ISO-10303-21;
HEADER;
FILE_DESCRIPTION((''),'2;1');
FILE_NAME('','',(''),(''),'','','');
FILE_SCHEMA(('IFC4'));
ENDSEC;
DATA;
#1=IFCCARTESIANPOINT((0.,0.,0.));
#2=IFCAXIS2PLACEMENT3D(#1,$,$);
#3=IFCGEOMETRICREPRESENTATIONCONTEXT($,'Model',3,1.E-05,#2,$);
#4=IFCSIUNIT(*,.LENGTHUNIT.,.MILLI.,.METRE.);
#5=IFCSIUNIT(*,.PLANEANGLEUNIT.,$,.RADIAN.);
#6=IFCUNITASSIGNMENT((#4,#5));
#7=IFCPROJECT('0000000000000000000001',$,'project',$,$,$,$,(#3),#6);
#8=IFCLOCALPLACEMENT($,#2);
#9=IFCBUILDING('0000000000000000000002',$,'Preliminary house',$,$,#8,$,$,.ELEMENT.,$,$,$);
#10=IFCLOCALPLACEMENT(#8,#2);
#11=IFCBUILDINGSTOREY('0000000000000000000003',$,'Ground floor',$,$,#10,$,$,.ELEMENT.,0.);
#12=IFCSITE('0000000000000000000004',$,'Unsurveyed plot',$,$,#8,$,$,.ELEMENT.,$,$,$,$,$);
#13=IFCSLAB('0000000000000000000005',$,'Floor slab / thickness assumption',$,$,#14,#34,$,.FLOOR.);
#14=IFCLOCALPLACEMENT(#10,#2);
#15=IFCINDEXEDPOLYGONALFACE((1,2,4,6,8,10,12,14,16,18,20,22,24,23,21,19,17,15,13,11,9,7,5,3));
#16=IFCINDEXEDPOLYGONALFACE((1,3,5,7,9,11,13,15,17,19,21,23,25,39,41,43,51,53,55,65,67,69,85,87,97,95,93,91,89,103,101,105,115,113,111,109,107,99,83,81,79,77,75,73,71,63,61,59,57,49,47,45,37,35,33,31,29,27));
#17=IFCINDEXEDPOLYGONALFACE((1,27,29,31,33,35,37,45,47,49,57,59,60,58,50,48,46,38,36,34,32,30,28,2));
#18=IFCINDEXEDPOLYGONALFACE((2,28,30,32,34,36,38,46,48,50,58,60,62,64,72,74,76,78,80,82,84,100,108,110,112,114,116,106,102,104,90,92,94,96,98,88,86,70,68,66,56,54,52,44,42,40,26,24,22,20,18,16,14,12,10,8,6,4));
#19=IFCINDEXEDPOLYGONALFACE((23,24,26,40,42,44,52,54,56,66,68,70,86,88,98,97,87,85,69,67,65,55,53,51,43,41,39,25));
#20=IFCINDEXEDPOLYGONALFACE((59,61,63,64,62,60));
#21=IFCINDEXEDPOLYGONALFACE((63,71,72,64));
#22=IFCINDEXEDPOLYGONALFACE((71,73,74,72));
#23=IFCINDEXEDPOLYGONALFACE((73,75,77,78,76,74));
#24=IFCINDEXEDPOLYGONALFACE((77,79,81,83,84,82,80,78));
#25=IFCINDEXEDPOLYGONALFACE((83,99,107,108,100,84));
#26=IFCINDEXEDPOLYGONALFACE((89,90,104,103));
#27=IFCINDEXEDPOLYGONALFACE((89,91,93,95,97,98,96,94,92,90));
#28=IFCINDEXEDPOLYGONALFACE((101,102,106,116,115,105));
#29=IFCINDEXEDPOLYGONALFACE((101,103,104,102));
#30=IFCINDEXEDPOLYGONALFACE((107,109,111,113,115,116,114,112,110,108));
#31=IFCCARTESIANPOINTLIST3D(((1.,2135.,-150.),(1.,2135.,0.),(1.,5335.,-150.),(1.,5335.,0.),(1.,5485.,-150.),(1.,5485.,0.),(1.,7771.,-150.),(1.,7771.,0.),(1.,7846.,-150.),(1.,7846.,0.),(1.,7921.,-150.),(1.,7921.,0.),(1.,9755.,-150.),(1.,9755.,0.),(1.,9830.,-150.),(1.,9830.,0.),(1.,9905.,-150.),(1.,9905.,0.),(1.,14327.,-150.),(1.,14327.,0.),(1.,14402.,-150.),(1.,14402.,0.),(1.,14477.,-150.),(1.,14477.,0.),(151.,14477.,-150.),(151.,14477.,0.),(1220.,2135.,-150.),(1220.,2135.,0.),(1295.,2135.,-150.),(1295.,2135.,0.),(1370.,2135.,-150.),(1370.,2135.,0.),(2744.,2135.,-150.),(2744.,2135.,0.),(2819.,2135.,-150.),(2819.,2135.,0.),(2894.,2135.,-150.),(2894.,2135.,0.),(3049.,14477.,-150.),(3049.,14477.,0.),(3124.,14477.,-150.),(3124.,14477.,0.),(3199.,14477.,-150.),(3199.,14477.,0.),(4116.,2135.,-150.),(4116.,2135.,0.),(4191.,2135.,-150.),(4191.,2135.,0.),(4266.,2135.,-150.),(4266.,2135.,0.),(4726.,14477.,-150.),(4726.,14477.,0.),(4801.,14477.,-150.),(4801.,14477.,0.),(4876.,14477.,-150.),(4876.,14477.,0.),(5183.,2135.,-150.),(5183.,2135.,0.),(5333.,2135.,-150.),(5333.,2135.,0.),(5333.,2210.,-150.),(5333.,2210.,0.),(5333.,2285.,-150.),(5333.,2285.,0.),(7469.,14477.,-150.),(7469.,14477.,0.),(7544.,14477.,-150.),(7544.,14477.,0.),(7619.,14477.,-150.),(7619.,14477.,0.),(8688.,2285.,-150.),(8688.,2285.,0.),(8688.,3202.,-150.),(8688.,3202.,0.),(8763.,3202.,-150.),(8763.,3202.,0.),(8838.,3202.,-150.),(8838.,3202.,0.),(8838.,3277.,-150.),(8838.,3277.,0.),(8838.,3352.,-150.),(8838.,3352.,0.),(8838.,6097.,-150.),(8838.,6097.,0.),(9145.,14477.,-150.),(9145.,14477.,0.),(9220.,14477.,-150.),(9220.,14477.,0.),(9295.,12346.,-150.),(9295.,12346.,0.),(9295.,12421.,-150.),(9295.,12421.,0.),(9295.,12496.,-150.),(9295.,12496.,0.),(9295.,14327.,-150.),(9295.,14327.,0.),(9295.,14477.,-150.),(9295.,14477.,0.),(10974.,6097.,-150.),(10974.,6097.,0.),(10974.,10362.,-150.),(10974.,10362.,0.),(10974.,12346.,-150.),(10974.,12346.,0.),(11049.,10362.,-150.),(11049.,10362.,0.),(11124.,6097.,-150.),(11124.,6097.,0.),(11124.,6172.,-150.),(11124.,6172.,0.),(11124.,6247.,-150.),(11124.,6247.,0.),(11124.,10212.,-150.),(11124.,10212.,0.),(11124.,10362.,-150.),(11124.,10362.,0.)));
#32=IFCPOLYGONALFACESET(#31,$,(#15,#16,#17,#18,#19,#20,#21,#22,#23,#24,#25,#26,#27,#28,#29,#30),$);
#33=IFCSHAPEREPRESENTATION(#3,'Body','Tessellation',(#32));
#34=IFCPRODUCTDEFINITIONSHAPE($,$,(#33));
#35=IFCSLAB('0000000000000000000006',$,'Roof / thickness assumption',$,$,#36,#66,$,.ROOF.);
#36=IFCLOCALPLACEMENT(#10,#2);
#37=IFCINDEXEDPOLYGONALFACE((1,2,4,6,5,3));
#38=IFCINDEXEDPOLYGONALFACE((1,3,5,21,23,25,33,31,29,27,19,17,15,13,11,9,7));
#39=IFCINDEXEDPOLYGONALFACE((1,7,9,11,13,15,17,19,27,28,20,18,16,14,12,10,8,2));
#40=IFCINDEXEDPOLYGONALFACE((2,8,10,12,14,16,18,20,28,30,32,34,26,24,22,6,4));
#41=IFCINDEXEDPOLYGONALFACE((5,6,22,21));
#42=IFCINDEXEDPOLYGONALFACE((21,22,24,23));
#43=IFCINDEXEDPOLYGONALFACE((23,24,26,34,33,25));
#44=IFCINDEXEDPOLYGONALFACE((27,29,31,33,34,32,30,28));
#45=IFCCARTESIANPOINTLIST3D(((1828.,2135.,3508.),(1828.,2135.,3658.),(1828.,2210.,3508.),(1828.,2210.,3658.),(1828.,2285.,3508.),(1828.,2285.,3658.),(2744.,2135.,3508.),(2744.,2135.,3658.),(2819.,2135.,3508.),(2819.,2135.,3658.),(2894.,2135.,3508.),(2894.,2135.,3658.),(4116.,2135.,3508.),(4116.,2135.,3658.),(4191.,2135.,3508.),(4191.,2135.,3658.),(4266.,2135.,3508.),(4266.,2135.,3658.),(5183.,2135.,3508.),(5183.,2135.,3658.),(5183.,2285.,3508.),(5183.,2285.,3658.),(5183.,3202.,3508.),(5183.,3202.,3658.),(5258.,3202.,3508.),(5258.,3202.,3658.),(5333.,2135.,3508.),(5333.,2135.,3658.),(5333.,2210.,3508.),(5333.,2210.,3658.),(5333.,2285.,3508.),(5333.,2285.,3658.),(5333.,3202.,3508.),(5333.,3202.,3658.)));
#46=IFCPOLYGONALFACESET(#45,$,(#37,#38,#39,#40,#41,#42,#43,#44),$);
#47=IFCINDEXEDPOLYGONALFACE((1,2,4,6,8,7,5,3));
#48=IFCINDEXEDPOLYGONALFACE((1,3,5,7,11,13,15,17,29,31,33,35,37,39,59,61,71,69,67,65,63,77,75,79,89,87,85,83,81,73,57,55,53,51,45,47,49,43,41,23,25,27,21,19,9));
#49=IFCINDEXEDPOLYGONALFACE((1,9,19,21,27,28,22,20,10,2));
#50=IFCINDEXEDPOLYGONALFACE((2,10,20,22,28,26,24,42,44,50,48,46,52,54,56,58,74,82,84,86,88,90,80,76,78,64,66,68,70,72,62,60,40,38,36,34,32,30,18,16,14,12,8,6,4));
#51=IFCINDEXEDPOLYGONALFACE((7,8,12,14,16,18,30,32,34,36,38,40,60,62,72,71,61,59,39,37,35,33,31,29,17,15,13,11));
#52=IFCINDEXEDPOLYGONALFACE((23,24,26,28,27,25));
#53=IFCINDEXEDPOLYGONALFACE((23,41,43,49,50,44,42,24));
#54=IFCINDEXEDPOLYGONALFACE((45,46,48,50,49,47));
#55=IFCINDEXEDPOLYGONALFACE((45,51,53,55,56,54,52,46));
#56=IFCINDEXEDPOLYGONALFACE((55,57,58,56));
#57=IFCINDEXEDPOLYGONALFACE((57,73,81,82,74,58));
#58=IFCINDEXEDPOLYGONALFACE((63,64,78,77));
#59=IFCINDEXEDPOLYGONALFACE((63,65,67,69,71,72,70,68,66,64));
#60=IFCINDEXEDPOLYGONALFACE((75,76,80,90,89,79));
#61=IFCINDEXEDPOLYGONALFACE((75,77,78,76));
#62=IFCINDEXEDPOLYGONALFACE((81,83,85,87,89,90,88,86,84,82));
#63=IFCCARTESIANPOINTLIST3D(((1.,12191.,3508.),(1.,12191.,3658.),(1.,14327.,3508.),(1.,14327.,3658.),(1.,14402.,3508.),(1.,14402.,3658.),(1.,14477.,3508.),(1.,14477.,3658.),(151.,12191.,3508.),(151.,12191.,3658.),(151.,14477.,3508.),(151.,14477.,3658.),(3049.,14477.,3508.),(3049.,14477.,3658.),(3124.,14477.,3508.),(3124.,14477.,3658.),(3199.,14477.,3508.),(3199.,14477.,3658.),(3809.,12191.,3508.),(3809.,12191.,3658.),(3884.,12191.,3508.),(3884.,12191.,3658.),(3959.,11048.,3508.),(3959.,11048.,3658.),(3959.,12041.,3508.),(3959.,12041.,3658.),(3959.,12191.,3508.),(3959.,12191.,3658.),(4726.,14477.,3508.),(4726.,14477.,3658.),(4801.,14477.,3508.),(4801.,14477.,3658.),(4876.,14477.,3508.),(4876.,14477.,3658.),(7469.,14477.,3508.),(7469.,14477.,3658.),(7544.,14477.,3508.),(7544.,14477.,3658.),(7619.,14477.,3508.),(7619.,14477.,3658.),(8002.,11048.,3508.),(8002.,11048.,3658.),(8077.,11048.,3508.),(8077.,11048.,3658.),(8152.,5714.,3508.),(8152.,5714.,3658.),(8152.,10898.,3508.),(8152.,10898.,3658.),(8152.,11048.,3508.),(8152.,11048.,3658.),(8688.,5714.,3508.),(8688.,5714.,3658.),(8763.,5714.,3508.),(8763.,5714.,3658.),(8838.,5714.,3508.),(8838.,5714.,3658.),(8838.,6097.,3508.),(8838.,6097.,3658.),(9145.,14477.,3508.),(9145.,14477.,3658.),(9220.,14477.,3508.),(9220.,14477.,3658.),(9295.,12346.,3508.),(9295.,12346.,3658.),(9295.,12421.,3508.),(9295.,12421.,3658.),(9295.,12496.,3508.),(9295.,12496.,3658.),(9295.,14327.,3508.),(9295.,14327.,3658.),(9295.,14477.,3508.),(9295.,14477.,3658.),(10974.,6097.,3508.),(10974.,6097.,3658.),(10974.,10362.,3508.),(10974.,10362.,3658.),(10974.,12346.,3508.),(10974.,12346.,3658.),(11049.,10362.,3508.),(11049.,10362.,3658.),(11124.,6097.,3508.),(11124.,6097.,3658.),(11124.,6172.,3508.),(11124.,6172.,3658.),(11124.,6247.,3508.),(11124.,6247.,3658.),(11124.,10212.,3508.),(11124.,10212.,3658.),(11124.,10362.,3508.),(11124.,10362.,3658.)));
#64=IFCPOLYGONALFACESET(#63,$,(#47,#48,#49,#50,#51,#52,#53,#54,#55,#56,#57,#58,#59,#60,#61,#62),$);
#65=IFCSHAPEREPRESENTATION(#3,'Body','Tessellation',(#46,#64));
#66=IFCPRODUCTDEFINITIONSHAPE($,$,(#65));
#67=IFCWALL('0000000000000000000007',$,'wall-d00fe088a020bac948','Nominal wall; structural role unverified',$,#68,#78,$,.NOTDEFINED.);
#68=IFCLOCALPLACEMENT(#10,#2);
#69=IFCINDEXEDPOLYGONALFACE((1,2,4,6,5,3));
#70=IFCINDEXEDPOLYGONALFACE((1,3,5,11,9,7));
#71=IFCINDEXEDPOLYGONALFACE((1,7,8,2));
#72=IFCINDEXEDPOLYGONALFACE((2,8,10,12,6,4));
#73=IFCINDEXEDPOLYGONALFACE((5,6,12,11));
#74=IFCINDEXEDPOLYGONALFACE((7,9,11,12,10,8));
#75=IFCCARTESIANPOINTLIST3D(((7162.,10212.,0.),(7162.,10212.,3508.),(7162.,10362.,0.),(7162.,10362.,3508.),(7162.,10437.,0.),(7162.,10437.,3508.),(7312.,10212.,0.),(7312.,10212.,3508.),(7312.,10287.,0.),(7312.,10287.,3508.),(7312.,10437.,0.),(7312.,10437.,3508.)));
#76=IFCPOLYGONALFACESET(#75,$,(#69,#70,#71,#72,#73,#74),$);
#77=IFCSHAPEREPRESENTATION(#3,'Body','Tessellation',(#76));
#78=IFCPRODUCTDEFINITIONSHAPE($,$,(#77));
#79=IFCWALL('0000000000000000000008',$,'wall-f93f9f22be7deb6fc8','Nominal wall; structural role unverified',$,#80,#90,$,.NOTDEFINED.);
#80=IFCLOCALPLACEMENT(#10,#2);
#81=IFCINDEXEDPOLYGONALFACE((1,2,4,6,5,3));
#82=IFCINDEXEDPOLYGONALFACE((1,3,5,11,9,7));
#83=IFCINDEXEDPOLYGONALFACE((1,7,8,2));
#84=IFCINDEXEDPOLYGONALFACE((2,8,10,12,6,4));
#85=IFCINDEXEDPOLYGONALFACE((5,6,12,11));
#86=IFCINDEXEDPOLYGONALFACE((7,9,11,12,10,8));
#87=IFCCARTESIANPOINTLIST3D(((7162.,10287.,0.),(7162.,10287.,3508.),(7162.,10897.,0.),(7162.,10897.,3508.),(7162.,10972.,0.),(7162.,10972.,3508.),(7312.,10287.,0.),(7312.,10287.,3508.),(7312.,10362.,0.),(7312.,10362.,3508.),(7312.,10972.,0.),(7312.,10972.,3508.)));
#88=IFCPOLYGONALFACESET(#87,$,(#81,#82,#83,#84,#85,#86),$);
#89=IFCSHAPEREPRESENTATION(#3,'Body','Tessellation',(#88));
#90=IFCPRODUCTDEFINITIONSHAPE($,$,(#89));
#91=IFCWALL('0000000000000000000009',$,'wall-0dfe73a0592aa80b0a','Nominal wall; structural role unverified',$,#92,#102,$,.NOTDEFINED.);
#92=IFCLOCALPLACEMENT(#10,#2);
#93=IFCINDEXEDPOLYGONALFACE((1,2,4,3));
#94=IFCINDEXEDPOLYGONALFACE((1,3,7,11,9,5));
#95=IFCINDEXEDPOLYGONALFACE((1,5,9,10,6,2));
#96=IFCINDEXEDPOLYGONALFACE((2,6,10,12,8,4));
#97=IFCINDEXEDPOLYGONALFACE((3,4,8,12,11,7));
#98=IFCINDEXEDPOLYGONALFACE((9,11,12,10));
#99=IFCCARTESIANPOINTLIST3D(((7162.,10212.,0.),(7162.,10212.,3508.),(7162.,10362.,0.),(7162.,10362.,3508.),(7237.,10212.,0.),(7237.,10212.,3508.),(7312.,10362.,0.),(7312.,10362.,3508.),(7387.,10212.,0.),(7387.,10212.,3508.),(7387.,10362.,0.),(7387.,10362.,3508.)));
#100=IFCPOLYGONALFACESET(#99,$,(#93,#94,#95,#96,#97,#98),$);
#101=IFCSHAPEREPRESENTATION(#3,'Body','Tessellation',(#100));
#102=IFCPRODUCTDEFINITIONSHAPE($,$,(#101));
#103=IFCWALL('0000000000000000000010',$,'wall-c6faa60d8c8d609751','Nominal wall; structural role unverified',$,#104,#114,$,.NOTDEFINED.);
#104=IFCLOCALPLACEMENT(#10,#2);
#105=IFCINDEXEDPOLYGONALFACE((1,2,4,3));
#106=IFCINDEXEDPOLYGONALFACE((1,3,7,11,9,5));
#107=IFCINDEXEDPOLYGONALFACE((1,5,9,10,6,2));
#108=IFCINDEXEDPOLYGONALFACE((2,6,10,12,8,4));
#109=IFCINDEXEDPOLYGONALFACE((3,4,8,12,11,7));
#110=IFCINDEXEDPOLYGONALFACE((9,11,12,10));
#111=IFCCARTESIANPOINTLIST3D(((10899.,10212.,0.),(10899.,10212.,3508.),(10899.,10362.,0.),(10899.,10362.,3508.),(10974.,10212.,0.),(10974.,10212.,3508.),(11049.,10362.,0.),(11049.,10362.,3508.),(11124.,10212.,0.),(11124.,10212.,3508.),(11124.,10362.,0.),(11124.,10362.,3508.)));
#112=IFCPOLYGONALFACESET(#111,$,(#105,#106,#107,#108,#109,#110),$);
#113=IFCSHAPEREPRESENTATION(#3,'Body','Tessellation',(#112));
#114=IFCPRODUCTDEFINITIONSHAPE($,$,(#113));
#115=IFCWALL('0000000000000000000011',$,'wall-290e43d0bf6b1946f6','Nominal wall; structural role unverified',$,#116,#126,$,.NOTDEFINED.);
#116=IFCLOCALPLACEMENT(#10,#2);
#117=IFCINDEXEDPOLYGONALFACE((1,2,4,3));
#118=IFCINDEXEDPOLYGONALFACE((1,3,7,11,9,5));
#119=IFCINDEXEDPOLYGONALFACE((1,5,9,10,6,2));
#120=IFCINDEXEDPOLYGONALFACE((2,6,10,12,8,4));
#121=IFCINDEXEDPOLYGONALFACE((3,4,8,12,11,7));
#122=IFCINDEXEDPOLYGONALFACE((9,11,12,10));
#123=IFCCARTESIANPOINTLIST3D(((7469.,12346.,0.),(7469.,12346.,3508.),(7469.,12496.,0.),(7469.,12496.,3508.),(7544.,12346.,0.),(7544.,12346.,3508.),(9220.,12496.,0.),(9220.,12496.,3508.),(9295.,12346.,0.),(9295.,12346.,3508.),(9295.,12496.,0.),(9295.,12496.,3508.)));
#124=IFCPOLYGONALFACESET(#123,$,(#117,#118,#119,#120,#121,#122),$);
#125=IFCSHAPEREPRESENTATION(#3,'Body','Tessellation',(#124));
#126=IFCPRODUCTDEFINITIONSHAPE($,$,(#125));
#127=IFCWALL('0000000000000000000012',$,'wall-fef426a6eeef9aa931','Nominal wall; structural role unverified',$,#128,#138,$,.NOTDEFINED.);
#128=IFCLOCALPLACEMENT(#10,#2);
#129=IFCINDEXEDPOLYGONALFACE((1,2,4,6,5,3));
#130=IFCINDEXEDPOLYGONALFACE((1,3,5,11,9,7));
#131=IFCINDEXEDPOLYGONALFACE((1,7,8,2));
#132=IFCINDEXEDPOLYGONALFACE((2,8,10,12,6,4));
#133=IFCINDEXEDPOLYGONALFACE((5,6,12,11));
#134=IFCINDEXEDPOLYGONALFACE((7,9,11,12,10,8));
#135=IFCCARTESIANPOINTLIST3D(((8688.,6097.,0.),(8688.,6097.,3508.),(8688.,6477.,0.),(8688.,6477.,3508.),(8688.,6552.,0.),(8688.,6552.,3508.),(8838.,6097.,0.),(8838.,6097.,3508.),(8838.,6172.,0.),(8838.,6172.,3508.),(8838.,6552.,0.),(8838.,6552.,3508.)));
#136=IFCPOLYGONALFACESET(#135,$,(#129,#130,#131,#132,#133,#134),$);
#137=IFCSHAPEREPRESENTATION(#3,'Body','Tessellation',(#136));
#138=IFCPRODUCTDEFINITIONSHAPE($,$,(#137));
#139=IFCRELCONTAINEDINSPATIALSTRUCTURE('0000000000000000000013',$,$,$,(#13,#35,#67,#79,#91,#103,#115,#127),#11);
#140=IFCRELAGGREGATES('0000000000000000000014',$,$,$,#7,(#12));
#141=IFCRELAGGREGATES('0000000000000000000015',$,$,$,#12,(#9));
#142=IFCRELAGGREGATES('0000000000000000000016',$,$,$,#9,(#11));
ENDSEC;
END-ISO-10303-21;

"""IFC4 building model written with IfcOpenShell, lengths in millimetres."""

from ifc_helpers import new_model, si_unit, frame, origin, place, context, project, spatial, polyline, outline, extrude, element, save


model = new_model("IFC4")

# Units and contexts
model_context = context("Model", 3, precision=1e-05, world=origin())
ifc_project = project(units=[si_unit("LENGTHUNIT", "METRE", prefix="MILLI"), si_unit("PLANEANGLEUNIT", "RADIAN")], contexts=[model_context])

# Site, building, storey
placement_1 = place(None, origin())
site = spatial("IfcSite", under=ifc_project, at=placement_1, Name="Unsurveyed plot", CompositionType="ELEMENT")
building = spatial("IfcBuilding", under=site, at=placement_1, Name="Preliminary house", CompositionType="ELEMENT")
placement_2 = place(placement_1, origin())
storey = spatial("IfcBuildingStorey", under=building, at=placement_2, Name="Ground floor", CompositionType="ELEMENT", Elevation=0.0)

# Slabs
element("IfcSlab", 1, at=placement_2, inside=storey, Name="Floor slab / thickness assumption", PredefinedType="FLOOR", context=model_context, shape_type="SweptSolid", body=[
    extrude(outline(polyline([(1370.0, 2135.0), (1295.0, 2135.0), (1220.0, 2135.0), (1.0, 2135.0), (1.0, 5335.0), (1.0, 5485.0), (1.0, 7771.0), (1.0, 7846.0), (1.0, 7921.0), (1.0, 9755.0), (1.0, 9830.0), (1.0, 9905.0), (1.0, 14327.0), (1.0, 14402.0), (1.0, 14477.0), (151.0, 14477.0), (3049.0, 14477.0), (3124.0, 14477.0), (3199.0, 14477.0), (4726.0, 14477.0), (4801.0, 14477.0), (4876.0, 14477.0), (7469.0, 14477.0), (7544.0, 14477.0), (7619.0, 14477.0), (9145.0, 14477.0), (9220.0, 14477.0), (9295.0, 14477.0), (9295.0, 14327.0), (9295.0, 12496.0), (9295.0, 12421.0), (9295.0, 12346.0), (10974.0, 12346.0), (10974.0, 10362.0), (11049.0, 10362.0), (11124.0, 10362.0), (11124.0, 10212.0), (11124.0, 6247.0), (11124.0, 6172.0), (11124.0, 6097.0), (10974.0, 6097.0), (8838.0, 6097.0), (8838.0, 3352.0), (8838.0, 3277.0), (8838.0, 3202.0), (8763.0, 3202.0), (8688.0, 3202.0), (8688.0, 2285.0), (5333.0, 2285.0), (5333.0, 2210.0), (5333.0, 2135.0), (5183.0, 2135.0), (4266.0, 2135.0), (4191.0, 2135.0), (4116.0, 2135.0), (2894.0, 2135.0), (2819.0, 2135.0), (2744.0, 2135.0), (1370.0, 2135.0)])), frame((0.0, 0.0, -150.0)), (0.0, 0.0, 1.0), 150.0),
])
element("IfcSlab", 2, at=placement_2, inside=storey, Name="Roof / thickness assumption", PredefinedType="ROOF", context=model_context, shape_type="SweptSolid", body=[
    extrude(outline(polyline([(5333.0, 2210.0), (5333.0, 2135.0), (5183.0, 2135.0), (4266.0, 2135.0), (4191.0, 2135.0), (4116.0, 2135.0), (2894.0, 2135.0), (2819.0, 2135.0), (2744.0, 2135.0), (1828.0, 2135.0), (1828.0, 2210.0), (1828.0, 2285.0), (5183.0, 2285.0), (5183.0, 3202.0), (5258.0, 3202.0), (5333.0, 3202.0), (5333.0, 2285.0), (5333.0, 2210.0)])), frame((0.0, 0.0, 3508.0)), (0.0, 0.0, 1.0), 150.0),
    extrude(outline(polyline([(1.0, 14402.0), (1.0, 14477.0), (151.0, 14477.0), (3049.0, 14477.0), (3124.0, 14477.0), (3199.0, 14477.0), (4726.0, 14477.0), (4801.0, 14477.0), (4876.0, 14477.0), (7469.0, 14477.0), (7544.0, 14477.0), (7619.0, 14477.0), (9145.0, 14477.0), (9220.0, 14477.0), (9295.0, 14477.0), (9295.0, 14327.0), (9295.0, 12496.0), (9295.0, 12421.0), (9295.0, 12346.0), (10974.0, 12346.0), (10974.0, 10362.0), (11049.0, 10362.0), (11124.0, 10362.0), (11124.0, 10212.0), (11124.0, 6247.0), (11124.0, 6172.0), (11124.0, 6097.0), (10974.0, 6097.0), (8838.0, 6097.0), (8838.0, 5714.0), (8763.0, 5714.0), (8688.0, 5714.0), (8152.0, 5714.0), (8152.0, 10898.0), (8152.0, 11048.0), (8077.0, 11048.0), (8002.0, 11048.0), (3959.0, 11048.0), (3959.0, 12041.0), (3959.0, 12191.0), (3884.0, 12191.0), (3809.0, 12191.0), (151.0, 12191.0), (1.0, 12191.0), (1.0, 14327.0), (1.0, 14402.0)])), frame((0.0, 0.0, 3508.0)), (0.0, 0.0, 1.0), 150.0),
])

# Walls
element("IfcWall", 3, at=placement_2, inside=storey, Name="wall-d00fe088a020bac948", Description="Nominal wall; structural role unverified", PredefinedType="NOTDEFINED", context=model_context, shape_type="SweptSolid", body=[
    extrude(outline(polyline([(7162.0, 10362.0), (7162.0, 10437.0), (7312.0, 10437.0), (7312.0, 10287.0), (7312.0, 10212.0), (7162.0, 10212.0), (7162.0, 10362.0)])), origin(), (0.0, 0.0, 1.0), 3508.0),
])
element("IfcWall", 4, at=placement_2, inside=storey, Name="wall-f93f9f22be7deb6fc8", Description="Nominal wall; structural role unverified", PredefinedType="NOTDEFINED", context=model_context, shape_type="SweptSolid", body=[
    extrude(outline(polyline([(7162.0, 10897.0), (7162.0, 10972.0), (7312.0, 10972.0), (7312.0, 10362.0), (7312.0, 10287.0), (7162.0, 10287.0), (7162.0, 10897.0)])), origin(), (0.0, 0.0, 1.0), 3508.0),
])
element("IfcWall", 5, at=placement_2, inside=storey, Name="wall-0dfe73a0592aa80b0a", Description="Nominal wall; structural role unverified", PredefinedType="NOTDEFINED", context=model_context, shape_type="SweptSolid", body=[
    extrude(outline(polyline([(7312.0, 10362.0), (7387.0, 10362.0), (7387.0, 10212.0), (7237.0, 10212.0), (7162.0, 10212.0), (7162.0, 10362.0), (7312.0, 10362.0)])), origin(), (0.0, 0.0, 1.0), 3508.0),
])

# Wall
element("IfcWall", 6, at=placement_2, inside=storey, Name="wall-c6faa60d8c8d609751", Description="Nominal wall; structural role unverified", PredefinedType="NOTDEFINED", context=model_context, shape_type="SweptSolid", body=[
    extrude(outline(polyline([(11049.0, 10362.0), (11124.0, 10362.0), (11124.0, 10212.0), (10974.0, 10212.0), (10899.0, 10212.0), (10899.0, 10362.0), (11049.0, 10362.0)])), origin(), (0.0, 0.0, 1.0), 3508.0),
])

# Wall
element("IfcWall", 7, at=placement_2, inside=storey, Name="wall-290e43d0bf6b1946f6", Description="Nominal wall; structural role unverified", PredefinedType="NOTDEFINED", context=model_context, shape_type="SweptSolid", body=[
    extrude(outline(polyline([(9220.0, 12496.0), (9295.0, 12496.0), (9295.0, 12346.0), (7544.0, 12346.0), (7469.0, 12346.0), (7469.0, 12496.0), (9220.0, 12496.0)])), origin(), (0.0, 0.0, 1.0), 3508.0),
])

# Wall
element("IfcWall", 8, at=placement_2, inside=storey, Name="wall-fef426a6eeef9aa931", Description="Nominal wall; structural role unverified", PredefinedType="NOTDEFINED", context=model_context, shape_type="SweptSolid", body=[
    extrude(outline(polyline([(8688.0, 6477.0), (8688.0, 6552.0), (8838.0, 6552.0), (8838.0, 6172.0), (8838.0, 6097.0), (8688.0, 6097.0), (8688.0, 6477.0)])), origin(), (0.0, 0.0, 1.0), 3508.0),
])

save(model, "model.ifc")
